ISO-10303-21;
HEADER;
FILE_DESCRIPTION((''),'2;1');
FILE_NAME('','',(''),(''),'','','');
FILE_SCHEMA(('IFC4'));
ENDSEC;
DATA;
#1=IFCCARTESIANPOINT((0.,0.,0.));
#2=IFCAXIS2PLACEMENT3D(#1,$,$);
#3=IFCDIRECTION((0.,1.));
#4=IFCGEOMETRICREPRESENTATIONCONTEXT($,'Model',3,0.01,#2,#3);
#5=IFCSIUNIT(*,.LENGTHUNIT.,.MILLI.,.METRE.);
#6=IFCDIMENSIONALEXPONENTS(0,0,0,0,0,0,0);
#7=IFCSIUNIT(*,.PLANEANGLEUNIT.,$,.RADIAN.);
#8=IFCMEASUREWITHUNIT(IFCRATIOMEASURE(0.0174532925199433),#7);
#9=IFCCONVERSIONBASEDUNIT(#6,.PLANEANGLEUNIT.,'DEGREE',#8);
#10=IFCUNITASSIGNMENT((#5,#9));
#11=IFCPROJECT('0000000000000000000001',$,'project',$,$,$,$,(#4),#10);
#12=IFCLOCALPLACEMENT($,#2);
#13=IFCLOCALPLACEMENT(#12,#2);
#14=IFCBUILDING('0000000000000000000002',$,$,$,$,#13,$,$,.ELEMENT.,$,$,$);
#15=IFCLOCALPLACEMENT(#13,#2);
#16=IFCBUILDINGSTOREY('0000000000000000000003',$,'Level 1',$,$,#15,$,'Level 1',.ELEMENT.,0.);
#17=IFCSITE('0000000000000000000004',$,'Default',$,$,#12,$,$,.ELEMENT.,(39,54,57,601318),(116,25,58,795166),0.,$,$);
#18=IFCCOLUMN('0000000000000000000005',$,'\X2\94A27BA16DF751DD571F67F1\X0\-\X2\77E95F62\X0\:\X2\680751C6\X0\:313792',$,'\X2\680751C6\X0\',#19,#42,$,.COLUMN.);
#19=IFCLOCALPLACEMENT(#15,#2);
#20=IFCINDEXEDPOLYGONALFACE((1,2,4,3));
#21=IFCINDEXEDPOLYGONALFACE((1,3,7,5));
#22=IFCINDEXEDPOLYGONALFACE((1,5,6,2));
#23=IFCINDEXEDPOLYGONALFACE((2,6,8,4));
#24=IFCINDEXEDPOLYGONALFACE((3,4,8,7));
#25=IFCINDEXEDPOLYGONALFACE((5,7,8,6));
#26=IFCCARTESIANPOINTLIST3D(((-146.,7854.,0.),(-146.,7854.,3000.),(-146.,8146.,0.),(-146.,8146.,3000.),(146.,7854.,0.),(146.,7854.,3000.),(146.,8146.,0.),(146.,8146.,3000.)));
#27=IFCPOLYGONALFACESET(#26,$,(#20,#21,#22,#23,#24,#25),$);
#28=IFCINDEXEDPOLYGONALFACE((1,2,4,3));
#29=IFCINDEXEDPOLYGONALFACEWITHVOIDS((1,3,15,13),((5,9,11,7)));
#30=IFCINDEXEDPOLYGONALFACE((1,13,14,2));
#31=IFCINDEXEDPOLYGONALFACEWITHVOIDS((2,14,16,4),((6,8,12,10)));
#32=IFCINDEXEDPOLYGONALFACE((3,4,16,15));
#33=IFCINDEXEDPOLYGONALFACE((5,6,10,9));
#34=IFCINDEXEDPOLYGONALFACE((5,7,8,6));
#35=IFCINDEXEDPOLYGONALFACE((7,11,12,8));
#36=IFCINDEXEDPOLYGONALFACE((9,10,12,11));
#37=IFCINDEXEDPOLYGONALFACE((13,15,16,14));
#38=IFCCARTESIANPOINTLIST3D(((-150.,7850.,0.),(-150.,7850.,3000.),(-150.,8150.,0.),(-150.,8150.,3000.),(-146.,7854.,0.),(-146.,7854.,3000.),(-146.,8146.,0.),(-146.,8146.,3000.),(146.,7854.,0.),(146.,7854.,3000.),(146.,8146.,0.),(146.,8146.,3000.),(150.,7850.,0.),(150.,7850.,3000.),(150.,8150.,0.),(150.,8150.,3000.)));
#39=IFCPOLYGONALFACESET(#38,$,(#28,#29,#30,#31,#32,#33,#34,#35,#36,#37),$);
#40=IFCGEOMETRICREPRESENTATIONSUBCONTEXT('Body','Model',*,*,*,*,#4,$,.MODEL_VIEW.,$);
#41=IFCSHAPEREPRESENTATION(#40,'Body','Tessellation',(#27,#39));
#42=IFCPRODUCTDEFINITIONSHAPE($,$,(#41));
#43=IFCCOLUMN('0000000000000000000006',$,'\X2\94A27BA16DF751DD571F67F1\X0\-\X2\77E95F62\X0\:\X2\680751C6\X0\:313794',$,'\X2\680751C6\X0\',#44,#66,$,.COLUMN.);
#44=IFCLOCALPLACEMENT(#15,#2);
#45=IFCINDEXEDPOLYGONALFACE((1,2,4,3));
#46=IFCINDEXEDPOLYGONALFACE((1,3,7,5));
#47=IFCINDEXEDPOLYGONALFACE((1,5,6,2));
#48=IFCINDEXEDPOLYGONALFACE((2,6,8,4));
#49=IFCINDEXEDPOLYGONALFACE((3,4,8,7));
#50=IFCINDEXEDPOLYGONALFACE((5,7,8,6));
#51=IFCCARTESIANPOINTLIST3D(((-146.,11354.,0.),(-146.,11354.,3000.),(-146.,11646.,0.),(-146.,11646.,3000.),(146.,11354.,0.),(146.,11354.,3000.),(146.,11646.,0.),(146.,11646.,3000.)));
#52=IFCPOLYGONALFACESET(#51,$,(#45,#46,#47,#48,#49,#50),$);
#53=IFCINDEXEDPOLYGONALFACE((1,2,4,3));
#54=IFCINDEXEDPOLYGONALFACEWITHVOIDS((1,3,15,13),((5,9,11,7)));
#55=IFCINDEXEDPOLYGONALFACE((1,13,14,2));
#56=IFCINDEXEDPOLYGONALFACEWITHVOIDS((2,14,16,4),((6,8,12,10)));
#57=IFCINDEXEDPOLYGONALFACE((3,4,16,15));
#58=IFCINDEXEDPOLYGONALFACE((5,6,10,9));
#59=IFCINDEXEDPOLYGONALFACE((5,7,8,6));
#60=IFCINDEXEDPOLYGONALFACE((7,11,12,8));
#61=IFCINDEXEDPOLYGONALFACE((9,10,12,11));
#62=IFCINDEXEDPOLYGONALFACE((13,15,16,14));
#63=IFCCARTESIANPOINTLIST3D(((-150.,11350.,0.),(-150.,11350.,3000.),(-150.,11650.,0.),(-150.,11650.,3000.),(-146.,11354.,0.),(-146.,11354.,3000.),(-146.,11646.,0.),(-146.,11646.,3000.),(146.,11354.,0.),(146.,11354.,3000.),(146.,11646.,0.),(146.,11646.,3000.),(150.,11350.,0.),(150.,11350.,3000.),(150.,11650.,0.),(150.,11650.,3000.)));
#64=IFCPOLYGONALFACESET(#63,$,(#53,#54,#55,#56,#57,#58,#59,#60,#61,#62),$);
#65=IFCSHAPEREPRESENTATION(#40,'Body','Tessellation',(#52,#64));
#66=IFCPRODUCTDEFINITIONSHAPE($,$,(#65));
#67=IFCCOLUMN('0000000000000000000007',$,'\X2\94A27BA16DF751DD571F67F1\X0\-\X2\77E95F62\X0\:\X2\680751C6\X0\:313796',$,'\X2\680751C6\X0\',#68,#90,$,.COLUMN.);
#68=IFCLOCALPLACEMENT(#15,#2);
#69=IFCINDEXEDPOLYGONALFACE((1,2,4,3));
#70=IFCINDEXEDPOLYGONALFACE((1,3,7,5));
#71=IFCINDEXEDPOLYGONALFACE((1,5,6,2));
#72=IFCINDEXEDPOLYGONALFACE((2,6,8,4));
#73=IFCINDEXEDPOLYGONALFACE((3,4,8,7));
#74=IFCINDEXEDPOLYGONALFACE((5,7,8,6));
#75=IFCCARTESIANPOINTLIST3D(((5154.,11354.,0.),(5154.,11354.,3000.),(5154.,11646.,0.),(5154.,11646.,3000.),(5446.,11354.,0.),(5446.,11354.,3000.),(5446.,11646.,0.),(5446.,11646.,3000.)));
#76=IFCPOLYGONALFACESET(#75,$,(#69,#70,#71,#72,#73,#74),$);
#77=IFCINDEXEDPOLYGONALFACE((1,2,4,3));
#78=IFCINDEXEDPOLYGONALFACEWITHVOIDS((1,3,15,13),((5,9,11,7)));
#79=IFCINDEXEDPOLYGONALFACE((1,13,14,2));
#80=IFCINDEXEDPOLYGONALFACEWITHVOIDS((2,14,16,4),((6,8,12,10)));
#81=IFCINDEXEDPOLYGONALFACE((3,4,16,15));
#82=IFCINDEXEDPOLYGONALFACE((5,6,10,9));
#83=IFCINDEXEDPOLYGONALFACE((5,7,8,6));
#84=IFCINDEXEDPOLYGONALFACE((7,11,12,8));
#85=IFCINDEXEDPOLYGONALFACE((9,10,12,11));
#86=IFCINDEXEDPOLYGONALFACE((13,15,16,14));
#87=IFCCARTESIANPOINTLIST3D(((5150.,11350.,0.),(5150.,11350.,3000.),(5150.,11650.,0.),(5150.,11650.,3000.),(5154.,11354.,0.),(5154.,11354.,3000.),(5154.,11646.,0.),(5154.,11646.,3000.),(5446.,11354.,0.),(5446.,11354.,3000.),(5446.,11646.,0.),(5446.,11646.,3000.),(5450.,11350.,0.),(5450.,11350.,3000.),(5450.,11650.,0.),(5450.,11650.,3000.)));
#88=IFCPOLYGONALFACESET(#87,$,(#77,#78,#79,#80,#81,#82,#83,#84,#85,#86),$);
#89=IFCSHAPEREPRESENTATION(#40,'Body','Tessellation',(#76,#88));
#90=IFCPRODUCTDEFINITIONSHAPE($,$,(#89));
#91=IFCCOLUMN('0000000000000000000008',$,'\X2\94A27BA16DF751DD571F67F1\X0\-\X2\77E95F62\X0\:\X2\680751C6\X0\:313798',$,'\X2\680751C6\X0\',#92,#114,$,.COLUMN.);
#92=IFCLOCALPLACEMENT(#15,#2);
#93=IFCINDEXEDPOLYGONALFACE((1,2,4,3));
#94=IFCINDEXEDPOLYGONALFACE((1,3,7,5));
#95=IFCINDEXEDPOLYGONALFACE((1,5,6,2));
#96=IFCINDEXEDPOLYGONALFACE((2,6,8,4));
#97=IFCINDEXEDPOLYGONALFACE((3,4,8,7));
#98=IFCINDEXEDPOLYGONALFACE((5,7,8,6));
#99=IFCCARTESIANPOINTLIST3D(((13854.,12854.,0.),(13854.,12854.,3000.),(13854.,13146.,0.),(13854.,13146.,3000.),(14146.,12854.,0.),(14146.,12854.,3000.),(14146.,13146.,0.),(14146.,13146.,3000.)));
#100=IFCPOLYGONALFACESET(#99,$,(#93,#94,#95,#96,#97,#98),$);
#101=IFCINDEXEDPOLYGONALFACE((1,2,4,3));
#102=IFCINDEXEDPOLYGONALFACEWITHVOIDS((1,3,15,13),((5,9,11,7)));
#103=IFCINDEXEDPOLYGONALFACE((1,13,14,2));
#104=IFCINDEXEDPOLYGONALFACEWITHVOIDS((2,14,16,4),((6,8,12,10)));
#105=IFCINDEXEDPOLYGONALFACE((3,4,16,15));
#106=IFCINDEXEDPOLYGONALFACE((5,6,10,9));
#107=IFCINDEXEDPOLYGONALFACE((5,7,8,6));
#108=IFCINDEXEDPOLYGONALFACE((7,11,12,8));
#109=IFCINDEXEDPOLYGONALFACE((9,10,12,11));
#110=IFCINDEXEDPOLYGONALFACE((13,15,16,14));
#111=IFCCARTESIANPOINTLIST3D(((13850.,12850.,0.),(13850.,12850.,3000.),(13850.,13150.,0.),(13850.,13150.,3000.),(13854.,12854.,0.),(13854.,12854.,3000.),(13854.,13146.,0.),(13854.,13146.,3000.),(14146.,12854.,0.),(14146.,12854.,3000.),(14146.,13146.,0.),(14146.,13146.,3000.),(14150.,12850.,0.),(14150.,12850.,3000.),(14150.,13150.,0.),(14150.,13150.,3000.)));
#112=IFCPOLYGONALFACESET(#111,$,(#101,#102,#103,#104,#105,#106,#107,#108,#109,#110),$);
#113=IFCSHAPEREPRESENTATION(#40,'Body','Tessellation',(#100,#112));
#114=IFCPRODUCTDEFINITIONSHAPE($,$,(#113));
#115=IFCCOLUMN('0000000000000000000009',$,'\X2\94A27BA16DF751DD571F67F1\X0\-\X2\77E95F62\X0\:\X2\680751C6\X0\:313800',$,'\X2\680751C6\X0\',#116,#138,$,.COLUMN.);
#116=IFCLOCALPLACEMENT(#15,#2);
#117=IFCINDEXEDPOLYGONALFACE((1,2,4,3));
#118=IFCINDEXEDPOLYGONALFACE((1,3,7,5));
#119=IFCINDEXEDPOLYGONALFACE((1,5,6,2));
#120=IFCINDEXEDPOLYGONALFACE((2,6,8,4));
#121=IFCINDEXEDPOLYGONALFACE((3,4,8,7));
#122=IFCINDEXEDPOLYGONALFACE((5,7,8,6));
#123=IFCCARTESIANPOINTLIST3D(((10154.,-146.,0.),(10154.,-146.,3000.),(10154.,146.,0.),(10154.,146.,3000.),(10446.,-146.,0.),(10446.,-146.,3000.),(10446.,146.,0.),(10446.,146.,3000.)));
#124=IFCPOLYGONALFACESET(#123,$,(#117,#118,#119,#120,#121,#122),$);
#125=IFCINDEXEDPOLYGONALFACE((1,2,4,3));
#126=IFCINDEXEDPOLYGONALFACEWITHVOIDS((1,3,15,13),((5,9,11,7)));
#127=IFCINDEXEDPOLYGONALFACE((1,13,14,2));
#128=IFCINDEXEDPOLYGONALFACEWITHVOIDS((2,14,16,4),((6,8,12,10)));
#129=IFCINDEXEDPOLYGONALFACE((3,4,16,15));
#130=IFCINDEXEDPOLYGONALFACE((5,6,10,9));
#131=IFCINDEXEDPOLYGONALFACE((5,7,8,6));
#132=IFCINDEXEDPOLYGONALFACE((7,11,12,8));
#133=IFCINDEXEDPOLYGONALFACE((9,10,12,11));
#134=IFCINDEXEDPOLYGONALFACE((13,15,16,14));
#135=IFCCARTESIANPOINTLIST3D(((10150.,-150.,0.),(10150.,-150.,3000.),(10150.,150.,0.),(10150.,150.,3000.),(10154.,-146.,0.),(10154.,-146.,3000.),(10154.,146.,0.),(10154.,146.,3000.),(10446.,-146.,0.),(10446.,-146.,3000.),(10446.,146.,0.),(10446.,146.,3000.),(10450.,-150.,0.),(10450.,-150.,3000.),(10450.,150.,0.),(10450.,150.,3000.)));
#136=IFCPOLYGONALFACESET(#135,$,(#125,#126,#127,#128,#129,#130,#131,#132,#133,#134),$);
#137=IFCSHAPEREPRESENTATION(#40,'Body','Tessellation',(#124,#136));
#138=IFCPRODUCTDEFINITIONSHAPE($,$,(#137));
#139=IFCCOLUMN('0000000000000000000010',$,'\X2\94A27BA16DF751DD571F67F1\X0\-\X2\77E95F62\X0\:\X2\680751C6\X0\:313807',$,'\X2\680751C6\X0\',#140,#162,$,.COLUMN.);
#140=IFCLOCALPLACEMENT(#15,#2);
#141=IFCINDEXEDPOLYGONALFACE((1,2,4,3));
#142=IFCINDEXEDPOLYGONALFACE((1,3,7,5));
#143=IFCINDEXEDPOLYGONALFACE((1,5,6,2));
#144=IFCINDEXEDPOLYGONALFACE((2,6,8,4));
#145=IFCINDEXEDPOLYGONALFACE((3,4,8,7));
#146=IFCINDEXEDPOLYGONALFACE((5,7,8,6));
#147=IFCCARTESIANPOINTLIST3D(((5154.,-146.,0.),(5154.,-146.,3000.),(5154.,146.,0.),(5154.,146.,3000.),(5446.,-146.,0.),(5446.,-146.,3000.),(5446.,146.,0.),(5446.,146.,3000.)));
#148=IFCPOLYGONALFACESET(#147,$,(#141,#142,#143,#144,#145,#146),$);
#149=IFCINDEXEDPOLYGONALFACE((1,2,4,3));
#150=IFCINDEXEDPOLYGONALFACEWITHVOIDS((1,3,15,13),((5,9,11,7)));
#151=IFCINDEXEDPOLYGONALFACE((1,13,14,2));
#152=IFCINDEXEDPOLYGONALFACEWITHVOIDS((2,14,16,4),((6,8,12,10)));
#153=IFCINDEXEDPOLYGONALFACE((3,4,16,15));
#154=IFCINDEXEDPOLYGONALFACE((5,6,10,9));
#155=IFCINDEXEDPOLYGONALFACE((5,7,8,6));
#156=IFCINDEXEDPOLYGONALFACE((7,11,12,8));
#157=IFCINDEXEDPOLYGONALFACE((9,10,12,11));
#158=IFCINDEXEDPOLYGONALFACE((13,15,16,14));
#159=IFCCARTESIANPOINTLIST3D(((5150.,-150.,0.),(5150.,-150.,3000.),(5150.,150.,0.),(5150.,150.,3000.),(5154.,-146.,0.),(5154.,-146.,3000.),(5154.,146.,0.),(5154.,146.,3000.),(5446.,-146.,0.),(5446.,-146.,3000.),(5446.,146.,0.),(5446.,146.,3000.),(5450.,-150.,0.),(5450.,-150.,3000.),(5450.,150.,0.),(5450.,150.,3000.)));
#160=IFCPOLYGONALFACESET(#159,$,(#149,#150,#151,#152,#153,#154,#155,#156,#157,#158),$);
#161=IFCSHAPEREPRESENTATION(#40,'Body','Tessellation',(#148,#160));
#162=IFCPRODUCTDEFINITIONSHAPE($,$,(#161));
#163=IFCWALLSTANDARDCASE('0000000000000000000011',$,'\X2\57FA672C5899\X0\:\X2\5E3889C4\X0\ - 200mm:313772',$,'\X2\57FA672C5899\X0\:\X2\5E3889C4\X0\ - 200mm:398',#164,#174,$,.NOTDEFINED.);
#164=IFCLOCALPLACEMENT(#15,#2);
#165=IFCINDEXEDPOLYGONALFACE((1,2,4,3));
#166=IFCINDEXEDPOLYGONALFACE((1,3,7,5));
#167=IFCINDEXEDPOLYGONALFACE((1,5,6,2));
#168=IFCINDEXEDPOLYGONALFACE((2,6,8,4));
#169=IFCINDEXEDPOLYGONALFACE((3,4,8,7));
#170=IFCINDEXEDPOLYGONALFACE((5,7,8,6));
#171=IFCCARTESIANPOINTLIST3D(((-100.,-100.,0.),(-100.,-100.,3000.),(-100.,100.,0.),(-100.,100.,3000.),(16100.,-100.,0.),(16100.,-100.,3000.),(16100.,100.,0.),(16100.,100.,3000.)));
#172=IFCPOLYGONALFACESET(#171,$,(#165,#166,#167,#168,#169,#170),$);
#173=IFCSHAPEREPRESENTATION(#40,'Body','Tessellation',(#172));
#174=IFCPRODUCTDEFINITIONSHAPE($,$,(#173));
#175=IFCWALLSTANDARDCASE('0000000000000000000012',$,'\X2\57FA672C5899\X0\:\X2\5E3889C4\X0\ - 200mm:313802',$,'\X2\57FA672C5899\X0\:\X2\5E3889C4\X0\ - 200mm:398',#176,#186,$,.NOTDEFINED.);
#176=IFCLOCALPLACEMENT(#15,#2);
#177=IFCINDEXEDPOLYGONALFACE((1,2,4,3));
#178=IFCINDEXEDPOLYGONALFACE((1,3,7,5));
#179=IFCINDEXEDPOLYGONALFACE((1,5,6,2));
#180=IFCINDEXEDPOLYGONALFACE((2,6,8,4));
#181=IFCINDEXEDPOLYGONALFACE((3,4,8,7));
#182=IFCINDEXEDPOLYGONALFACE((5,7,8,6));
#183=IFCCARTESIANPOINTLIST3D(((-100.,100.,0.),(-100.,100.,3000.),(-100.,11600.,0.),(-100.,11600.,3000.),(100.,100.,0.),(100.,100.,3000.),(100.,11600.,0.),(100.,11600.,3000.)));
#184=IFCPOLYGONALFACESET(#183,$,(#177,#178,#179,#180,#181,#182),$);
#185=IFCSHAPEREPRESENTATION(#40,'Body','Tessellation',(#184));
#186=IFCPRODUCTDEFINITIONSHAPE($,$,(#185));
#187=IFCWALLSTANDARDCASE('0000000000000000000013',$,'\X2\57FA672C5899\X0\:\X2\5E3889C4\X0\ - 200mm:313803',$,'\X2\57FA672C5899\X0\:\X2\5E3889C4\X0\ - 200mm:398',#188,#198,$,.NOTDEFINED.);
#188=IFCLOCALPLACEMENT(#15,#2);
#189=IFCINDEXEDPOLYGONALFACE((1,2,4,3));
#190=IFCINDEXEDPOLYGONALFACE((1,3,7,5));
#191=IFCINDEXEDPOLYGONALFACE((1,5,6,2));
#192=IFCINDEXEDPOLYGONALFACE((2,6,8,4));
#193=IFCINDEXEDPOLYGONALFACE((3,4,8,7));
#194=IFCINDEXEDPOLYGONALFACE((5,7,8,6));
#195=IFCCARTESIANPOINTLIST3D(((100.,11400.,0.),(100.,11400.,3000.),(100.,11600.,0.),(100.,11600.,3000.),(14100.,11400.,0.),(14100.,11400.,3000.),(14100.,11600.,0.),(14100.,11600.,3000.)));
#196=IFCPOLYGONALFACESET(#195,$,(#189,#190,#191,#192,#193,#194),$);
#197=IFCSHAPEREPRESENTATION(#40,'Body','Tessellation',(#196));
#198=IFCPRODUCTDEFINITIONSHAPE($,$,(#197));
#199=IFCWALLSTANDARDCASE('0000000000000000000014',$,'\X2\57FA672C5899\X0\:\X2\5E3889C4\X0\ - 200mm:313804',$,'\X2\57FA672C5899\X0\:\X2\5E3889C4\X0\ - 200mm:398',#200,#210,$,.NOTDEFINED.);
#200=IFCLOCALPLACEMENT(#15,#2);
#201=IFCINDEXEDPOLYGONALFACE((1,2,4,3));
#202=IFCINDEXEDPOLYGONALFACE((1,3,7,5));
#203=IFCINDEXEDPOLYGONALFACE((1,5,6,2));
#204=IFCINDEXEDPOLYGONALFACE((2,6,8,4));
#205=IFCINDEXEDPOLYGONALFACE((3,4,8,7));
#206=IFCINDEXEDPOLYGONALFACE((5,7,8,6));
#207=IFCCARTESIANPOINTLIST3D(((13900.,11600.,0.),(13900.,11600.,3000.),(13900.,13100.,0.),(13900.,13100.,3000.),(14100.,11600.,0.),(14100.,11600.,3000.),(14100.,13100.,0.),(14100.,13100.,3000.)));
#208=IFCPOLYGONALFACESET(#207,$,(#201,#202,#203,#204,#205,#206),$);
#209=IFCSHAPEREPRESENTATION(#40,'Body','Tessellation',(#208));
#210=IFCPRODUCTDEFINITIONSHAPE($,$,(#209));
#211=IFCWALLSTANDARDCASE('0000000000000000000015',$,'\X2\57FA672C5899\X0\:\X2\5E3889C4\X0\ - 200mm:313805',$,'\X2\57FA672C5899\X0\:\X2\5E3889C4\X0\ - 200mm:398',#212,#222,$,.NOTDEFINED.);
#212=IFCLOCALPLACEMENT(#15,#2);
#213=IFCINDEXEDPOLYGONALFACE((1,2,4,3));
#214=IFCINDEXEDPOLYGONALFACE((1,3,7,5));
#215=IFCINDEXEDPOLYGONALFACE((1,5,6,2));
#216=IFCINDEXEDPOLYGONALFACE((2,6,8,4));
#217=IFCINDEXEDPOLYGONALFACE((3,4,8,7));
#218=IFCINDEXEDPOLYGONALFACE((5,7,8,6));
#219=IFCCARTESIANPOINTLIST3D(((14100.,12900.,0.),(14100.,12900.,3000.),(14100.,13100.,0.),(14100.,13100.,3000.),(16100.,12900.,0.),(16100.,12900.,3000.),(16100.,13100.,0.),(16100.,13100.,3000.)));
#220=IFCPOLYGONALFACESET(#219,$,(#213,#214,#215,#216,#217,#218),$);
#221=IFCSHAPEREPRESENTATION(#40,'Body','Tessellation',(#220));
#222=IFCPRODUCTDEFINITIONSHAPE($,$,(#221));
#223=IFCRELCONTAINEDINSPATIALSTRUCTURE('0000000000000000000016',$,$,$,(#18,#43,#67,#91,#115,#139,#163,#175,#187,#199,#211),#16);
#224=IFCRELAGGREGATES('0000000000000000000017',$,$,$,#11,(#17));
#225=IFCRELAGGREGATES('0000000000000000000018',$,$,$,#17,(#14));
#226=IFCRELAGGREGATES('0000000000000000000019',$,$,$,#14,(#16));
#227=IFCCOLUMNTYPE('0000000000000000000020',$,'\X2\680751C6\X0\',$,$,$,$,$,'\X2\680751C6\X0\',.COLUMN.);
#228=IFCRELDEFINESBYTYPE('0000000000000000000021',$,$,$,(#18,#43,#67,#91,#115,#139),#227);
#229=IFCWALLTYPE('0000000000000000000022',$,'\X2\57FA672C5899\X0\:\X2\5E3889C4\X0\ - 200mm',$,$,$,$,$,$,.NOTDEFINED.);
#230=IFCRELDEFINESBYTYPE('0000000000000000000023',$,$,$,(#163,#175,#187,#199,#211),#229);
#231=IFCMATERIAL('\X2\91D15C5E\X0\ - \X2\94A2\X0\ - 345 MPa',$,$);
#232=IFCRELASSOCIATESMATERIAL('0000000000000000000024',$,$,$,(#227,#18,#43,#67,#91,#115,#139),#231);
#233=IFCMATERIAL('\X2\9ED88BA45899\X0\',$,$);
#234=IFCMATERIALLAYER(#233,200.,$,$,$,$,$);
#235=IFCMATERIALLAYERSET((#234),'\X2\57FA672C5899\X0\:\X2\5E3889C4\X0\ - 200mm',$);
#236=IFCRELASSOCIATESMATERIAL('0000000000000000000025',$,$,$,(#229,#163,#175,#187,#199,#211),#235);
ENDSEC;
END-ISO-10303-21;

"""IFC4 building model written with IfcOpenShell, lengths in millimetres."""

from ifc_helpers import new_model, entity, si_unit, converted_unit, direction, frame, frame_2d, origin, origin_2d_with_axis, place, context, subcontext, project, spatial, polyline, rectangle, outline, extrude, source, transform, mapped, material, layer, layer_set, layer_usage, type_object, type_shapes, element, save


model = new_model("IFC4")

# Units and contexts
model_context = context("Model", 3, precision=0.01, world=origin(), true_north=direction((0.0, 1.0)))
body_context = subcontext(model_context, "Body", "Model", "MODEL_VIEW")
ifc_project = project(units=[si_unit("LENGTHUNIT", "METRE", prefix="MILLI"), converted_unit("PLANEANGLEUNIT", "DEGREE", entity("IfcRatioMeasure", 0.0174532925199433), si_unit("PLANEANGLEUNIT", "RADIAN"), dimensions=[0, 0, 0, 0, 0, 0, 0])], contexts=[model_context])

# Site, building, storey
site_placement = place(None, origin())
site = spatial("IfcSite", under=ifc_project, at=site_placement, Name="Default", CompositionType="ELEMENT", RefLatitude=(39, 54, 57, 601318), RefLongitude=(116, 25, 58, 795166), RefElevation=0.0)
building_placement = place(site_placement, origin())
building = spatial("IfcBuilding", under=site, at=building_placement, CompositionType="ELEMENT")
storey_placement = place(building_placement, origin())
storey = spatial("IfcBuildingStorey", under=building, at=storey_placement, Name="Level 1", LongName="Level 1", CompositionType="ELEMENT", Elevation=0.0)

# Columns
ifc_material_1 = material(Name="金属 - 钢 - 345 MPa")
column_type = type_object("IfcColumnType", Name="标准", ElementType="标准", PredefinedType="COLUMN", material=ifc_material_1)
shared_shape = source(origin(), body_context, "Body", "SweptSolid", [
    extrude(rectangle(XDim=292.0, YDim=292.0, at=origin_2d_with_axis()), frame((0.0, 0.0, 0.0), z_axis=(0.0, 0.0, 1.0), x_axis=(-1.0, 0.0, 0.0)), (0.0, 0.0, 1.0), 3000.0),
    extrude(outline(polyline([(-150.0, -150.0), (150.0, -150.0), (150.0, 150.0), (-150.0, 150.0), (-150.0, -150.0)]), holes=[polyline([(-146.0, -146.0), (-146.0, 146.0), (146.0, 146.0), (146.0, -146.0), (-146.0, -146.0)])]), frame((0.0, 0.0, 0.0), z_axis=(0.0, 0.0, 1.0), x_axis=(-1.0, 0.0, 0.0)), (0.0, 0.0, 1.0), 3000.0),
])
type_shapes(column_type, [shared_shape])
for number, where, name in (
    (1, (0.0, 8000.0, 0.0), "钢管混凝土柱-矩形:标准:313792"),
    (2, (0.0, 11500.0, 0.0), "钢管混凝土柱-矩形:标准:313794"),
    (3, (5300.0, 11500.0, 0.0), "钢管混凝土柱-矩形:标准:313796"),
    (4, (14000.0, 13000.0, 0.0), "钢管混凝土柱-矩形:标准:313798"),
    (5, (10300.0, 0.0, 0.0), "钢管混凝土柱-矩形:标准:313800"),
    (6, (5300.0, 0.0, 0.0), "钢管混凝土柱-矩形:标准:313807"),
):
    element("IfcColumn", number, at=place(storey_placement, frame(where)), inside=storey, type_object=column_type, material=ifc_material_1, Name=name, ObjectType="标准", PredefinedType="COLUMN", context=body_context, shape_type="MappedRepresentation", body=[
        mapped(shared_shape, transform((0.0, 0.0, 0.0), scale=1.0)),
    ])

# Walls
ifc_material_2 = material(Name="默认墙")
ifc_layer_1 = layer(ifc_material_2, 200.0)
ifc_layer_set_1 = layer_set([ifc_layer_1], Name="基本墙:常规 - 200mm")
ifc_layer_usage_1 = layer_usage(ifc_layer_set_1, "AXIS2", "NEGATIVE", 100.0)
wall_type = type_object("IfcWallType", Name="基本墙:常规 - 200mm", PredefinedType="NOTDEFINED", material=ifc_layer_set_1)
wall_1_placement = place(storey_placement, frame((16100.0, 0.0, 0.0), z_axis=(0.0, 0.0, 1.0), x_axis=(-1.0, 0.0, 0.0)))
element("IfcWallStandardCase", 7, at=wall_1_placement, inside=storey, type_object=wall_type, material=ifc_layer_usage_1, Name="基本墙:常规 - 200mm:313772", ObjectType="基本墙:常规 - 200mm:398", PredefinedType="NOTDEFINED", context=body_context, shape_type="SweptSolid", body=[
    extrude(rectangle(XDim=16200.0, YDim=200.0, at=frame_2d((8100.0, 0.0), x_axis=(-1.0, 0.0))), origin(), (0.0, 0.0, 1.0), 3000.0),
])
ifc_layer_usage_2 = layer_usage(ifc_layer_set_1, "AXIS2", "NEGATIVE", 100.0)
wall_2_placement = place(storey_placement, frame((0.0, 100.0, 0.0), z_axis=(0.0, 0.0, 1.0), x_axis=(0.0, 1.0, 0.0)))
element("IfcWallStandardCase", 8, at=wall_2_placement, inside=storey, type_object=wall_type, material=ifc_layer_usage_2, Name="基本墙:常规 - 200mm:313802", ObjectType="基本墙:常规 - 200mm:398", PredefinedType="NOTDEFINED", context=body_context, shape_type="SweptSolid", body=[
    extrude(rectangle(XDim=11500.0, YDim=200.0, at=frame_2d((5750.0, 0.0), x_axis=(-1.0, 0.0))), origin(), (0.0, 0.0, 1.0), 3000.0),
])
ifc_layer_usage_3 = layer_usage(ifc_layer_set_1, "AXIS2", "NEGATIVE", 100.0)
wall_3_placement = place(storey_placement, frame((100.0, 11500.0, 0.0)))
element("IfcWallStandardCase", 9, at=wall_3_placement, inside=storey, type_object=wall_type, material=ifc_layer_usage_3, Name="基本墙:常规 - 200mm:313803", ObjectType="基本墙:常规 - 200mm:398", PredefinedType="NOTDEFINED", context=body_context, shape_type="SweptSolid", body=[
    extrude(rectangle(XDim=14000.0, YDim=200.0, at=frame_2d((7000.0, 0.0), x_axis=(-1.0, 0.0))), origin(), (0.0, 0.0, 1.0), 3000.0),
])
ifc_layer_usage_4 = layer_usage(ifc_layer_set_1, "AXIS2", "NEGATIVE", 100.0)
wall_4_placement = place(storey_placement, frame((14000.0, 11600.0, 0.0), z_axis=(0.0, 0.0, 1.0), x_axis=(0.0, 1.0, 0.0)))
element("IfcWallStandardCase", 10, at=wall_4_placement, inside=storey, type_object=wall_type, material=ifc_layer_usage_4, Name="基本墙:常规 - 200mm:313804", ObjectType="基本墙:常规 - 200mm:398", PredefinedType="NOTDEFINED", context=body_context, shape_type="SweptSolid", body=[
    extrude(rectangle(XDim=1500.0, YDim=200.0, at=frame_2d((750.0, 0.0), x_axis=(-1.0, 0.0))), origin(), (0.0, 0.0, 1.0), 3000.0),
])
ifc_layer_usage_5 = layer_usage(ifc_layer_set_1, "AXIS2", "NEGATIVE", 100.0)
wall_5_placement = place(storey_placement, frame((14100.0, 13000.0, 0.0)))
element("IfcWallStandardCase", 11, at=wall_5_placement, inside=storey, type_object=wall_type, material=ifc_layer_usage_5, Name="基本墙:常规 - 200mm:313805", ObjectType="基本墙:常规 - 200mm:398", PredefinedType="NOTDEFINED", context=body_context, shape_type="SweptSolid", body=[
    extrude(rectangle(XDim=2000.0, YDim=200.0, at=frame_2d((1000.0, 0.0), x_axis=(-1.0, 0.0))), origin(), (0.0, 0.0, 1.0), 3000.0),
])

save(model, "model.ifc")
